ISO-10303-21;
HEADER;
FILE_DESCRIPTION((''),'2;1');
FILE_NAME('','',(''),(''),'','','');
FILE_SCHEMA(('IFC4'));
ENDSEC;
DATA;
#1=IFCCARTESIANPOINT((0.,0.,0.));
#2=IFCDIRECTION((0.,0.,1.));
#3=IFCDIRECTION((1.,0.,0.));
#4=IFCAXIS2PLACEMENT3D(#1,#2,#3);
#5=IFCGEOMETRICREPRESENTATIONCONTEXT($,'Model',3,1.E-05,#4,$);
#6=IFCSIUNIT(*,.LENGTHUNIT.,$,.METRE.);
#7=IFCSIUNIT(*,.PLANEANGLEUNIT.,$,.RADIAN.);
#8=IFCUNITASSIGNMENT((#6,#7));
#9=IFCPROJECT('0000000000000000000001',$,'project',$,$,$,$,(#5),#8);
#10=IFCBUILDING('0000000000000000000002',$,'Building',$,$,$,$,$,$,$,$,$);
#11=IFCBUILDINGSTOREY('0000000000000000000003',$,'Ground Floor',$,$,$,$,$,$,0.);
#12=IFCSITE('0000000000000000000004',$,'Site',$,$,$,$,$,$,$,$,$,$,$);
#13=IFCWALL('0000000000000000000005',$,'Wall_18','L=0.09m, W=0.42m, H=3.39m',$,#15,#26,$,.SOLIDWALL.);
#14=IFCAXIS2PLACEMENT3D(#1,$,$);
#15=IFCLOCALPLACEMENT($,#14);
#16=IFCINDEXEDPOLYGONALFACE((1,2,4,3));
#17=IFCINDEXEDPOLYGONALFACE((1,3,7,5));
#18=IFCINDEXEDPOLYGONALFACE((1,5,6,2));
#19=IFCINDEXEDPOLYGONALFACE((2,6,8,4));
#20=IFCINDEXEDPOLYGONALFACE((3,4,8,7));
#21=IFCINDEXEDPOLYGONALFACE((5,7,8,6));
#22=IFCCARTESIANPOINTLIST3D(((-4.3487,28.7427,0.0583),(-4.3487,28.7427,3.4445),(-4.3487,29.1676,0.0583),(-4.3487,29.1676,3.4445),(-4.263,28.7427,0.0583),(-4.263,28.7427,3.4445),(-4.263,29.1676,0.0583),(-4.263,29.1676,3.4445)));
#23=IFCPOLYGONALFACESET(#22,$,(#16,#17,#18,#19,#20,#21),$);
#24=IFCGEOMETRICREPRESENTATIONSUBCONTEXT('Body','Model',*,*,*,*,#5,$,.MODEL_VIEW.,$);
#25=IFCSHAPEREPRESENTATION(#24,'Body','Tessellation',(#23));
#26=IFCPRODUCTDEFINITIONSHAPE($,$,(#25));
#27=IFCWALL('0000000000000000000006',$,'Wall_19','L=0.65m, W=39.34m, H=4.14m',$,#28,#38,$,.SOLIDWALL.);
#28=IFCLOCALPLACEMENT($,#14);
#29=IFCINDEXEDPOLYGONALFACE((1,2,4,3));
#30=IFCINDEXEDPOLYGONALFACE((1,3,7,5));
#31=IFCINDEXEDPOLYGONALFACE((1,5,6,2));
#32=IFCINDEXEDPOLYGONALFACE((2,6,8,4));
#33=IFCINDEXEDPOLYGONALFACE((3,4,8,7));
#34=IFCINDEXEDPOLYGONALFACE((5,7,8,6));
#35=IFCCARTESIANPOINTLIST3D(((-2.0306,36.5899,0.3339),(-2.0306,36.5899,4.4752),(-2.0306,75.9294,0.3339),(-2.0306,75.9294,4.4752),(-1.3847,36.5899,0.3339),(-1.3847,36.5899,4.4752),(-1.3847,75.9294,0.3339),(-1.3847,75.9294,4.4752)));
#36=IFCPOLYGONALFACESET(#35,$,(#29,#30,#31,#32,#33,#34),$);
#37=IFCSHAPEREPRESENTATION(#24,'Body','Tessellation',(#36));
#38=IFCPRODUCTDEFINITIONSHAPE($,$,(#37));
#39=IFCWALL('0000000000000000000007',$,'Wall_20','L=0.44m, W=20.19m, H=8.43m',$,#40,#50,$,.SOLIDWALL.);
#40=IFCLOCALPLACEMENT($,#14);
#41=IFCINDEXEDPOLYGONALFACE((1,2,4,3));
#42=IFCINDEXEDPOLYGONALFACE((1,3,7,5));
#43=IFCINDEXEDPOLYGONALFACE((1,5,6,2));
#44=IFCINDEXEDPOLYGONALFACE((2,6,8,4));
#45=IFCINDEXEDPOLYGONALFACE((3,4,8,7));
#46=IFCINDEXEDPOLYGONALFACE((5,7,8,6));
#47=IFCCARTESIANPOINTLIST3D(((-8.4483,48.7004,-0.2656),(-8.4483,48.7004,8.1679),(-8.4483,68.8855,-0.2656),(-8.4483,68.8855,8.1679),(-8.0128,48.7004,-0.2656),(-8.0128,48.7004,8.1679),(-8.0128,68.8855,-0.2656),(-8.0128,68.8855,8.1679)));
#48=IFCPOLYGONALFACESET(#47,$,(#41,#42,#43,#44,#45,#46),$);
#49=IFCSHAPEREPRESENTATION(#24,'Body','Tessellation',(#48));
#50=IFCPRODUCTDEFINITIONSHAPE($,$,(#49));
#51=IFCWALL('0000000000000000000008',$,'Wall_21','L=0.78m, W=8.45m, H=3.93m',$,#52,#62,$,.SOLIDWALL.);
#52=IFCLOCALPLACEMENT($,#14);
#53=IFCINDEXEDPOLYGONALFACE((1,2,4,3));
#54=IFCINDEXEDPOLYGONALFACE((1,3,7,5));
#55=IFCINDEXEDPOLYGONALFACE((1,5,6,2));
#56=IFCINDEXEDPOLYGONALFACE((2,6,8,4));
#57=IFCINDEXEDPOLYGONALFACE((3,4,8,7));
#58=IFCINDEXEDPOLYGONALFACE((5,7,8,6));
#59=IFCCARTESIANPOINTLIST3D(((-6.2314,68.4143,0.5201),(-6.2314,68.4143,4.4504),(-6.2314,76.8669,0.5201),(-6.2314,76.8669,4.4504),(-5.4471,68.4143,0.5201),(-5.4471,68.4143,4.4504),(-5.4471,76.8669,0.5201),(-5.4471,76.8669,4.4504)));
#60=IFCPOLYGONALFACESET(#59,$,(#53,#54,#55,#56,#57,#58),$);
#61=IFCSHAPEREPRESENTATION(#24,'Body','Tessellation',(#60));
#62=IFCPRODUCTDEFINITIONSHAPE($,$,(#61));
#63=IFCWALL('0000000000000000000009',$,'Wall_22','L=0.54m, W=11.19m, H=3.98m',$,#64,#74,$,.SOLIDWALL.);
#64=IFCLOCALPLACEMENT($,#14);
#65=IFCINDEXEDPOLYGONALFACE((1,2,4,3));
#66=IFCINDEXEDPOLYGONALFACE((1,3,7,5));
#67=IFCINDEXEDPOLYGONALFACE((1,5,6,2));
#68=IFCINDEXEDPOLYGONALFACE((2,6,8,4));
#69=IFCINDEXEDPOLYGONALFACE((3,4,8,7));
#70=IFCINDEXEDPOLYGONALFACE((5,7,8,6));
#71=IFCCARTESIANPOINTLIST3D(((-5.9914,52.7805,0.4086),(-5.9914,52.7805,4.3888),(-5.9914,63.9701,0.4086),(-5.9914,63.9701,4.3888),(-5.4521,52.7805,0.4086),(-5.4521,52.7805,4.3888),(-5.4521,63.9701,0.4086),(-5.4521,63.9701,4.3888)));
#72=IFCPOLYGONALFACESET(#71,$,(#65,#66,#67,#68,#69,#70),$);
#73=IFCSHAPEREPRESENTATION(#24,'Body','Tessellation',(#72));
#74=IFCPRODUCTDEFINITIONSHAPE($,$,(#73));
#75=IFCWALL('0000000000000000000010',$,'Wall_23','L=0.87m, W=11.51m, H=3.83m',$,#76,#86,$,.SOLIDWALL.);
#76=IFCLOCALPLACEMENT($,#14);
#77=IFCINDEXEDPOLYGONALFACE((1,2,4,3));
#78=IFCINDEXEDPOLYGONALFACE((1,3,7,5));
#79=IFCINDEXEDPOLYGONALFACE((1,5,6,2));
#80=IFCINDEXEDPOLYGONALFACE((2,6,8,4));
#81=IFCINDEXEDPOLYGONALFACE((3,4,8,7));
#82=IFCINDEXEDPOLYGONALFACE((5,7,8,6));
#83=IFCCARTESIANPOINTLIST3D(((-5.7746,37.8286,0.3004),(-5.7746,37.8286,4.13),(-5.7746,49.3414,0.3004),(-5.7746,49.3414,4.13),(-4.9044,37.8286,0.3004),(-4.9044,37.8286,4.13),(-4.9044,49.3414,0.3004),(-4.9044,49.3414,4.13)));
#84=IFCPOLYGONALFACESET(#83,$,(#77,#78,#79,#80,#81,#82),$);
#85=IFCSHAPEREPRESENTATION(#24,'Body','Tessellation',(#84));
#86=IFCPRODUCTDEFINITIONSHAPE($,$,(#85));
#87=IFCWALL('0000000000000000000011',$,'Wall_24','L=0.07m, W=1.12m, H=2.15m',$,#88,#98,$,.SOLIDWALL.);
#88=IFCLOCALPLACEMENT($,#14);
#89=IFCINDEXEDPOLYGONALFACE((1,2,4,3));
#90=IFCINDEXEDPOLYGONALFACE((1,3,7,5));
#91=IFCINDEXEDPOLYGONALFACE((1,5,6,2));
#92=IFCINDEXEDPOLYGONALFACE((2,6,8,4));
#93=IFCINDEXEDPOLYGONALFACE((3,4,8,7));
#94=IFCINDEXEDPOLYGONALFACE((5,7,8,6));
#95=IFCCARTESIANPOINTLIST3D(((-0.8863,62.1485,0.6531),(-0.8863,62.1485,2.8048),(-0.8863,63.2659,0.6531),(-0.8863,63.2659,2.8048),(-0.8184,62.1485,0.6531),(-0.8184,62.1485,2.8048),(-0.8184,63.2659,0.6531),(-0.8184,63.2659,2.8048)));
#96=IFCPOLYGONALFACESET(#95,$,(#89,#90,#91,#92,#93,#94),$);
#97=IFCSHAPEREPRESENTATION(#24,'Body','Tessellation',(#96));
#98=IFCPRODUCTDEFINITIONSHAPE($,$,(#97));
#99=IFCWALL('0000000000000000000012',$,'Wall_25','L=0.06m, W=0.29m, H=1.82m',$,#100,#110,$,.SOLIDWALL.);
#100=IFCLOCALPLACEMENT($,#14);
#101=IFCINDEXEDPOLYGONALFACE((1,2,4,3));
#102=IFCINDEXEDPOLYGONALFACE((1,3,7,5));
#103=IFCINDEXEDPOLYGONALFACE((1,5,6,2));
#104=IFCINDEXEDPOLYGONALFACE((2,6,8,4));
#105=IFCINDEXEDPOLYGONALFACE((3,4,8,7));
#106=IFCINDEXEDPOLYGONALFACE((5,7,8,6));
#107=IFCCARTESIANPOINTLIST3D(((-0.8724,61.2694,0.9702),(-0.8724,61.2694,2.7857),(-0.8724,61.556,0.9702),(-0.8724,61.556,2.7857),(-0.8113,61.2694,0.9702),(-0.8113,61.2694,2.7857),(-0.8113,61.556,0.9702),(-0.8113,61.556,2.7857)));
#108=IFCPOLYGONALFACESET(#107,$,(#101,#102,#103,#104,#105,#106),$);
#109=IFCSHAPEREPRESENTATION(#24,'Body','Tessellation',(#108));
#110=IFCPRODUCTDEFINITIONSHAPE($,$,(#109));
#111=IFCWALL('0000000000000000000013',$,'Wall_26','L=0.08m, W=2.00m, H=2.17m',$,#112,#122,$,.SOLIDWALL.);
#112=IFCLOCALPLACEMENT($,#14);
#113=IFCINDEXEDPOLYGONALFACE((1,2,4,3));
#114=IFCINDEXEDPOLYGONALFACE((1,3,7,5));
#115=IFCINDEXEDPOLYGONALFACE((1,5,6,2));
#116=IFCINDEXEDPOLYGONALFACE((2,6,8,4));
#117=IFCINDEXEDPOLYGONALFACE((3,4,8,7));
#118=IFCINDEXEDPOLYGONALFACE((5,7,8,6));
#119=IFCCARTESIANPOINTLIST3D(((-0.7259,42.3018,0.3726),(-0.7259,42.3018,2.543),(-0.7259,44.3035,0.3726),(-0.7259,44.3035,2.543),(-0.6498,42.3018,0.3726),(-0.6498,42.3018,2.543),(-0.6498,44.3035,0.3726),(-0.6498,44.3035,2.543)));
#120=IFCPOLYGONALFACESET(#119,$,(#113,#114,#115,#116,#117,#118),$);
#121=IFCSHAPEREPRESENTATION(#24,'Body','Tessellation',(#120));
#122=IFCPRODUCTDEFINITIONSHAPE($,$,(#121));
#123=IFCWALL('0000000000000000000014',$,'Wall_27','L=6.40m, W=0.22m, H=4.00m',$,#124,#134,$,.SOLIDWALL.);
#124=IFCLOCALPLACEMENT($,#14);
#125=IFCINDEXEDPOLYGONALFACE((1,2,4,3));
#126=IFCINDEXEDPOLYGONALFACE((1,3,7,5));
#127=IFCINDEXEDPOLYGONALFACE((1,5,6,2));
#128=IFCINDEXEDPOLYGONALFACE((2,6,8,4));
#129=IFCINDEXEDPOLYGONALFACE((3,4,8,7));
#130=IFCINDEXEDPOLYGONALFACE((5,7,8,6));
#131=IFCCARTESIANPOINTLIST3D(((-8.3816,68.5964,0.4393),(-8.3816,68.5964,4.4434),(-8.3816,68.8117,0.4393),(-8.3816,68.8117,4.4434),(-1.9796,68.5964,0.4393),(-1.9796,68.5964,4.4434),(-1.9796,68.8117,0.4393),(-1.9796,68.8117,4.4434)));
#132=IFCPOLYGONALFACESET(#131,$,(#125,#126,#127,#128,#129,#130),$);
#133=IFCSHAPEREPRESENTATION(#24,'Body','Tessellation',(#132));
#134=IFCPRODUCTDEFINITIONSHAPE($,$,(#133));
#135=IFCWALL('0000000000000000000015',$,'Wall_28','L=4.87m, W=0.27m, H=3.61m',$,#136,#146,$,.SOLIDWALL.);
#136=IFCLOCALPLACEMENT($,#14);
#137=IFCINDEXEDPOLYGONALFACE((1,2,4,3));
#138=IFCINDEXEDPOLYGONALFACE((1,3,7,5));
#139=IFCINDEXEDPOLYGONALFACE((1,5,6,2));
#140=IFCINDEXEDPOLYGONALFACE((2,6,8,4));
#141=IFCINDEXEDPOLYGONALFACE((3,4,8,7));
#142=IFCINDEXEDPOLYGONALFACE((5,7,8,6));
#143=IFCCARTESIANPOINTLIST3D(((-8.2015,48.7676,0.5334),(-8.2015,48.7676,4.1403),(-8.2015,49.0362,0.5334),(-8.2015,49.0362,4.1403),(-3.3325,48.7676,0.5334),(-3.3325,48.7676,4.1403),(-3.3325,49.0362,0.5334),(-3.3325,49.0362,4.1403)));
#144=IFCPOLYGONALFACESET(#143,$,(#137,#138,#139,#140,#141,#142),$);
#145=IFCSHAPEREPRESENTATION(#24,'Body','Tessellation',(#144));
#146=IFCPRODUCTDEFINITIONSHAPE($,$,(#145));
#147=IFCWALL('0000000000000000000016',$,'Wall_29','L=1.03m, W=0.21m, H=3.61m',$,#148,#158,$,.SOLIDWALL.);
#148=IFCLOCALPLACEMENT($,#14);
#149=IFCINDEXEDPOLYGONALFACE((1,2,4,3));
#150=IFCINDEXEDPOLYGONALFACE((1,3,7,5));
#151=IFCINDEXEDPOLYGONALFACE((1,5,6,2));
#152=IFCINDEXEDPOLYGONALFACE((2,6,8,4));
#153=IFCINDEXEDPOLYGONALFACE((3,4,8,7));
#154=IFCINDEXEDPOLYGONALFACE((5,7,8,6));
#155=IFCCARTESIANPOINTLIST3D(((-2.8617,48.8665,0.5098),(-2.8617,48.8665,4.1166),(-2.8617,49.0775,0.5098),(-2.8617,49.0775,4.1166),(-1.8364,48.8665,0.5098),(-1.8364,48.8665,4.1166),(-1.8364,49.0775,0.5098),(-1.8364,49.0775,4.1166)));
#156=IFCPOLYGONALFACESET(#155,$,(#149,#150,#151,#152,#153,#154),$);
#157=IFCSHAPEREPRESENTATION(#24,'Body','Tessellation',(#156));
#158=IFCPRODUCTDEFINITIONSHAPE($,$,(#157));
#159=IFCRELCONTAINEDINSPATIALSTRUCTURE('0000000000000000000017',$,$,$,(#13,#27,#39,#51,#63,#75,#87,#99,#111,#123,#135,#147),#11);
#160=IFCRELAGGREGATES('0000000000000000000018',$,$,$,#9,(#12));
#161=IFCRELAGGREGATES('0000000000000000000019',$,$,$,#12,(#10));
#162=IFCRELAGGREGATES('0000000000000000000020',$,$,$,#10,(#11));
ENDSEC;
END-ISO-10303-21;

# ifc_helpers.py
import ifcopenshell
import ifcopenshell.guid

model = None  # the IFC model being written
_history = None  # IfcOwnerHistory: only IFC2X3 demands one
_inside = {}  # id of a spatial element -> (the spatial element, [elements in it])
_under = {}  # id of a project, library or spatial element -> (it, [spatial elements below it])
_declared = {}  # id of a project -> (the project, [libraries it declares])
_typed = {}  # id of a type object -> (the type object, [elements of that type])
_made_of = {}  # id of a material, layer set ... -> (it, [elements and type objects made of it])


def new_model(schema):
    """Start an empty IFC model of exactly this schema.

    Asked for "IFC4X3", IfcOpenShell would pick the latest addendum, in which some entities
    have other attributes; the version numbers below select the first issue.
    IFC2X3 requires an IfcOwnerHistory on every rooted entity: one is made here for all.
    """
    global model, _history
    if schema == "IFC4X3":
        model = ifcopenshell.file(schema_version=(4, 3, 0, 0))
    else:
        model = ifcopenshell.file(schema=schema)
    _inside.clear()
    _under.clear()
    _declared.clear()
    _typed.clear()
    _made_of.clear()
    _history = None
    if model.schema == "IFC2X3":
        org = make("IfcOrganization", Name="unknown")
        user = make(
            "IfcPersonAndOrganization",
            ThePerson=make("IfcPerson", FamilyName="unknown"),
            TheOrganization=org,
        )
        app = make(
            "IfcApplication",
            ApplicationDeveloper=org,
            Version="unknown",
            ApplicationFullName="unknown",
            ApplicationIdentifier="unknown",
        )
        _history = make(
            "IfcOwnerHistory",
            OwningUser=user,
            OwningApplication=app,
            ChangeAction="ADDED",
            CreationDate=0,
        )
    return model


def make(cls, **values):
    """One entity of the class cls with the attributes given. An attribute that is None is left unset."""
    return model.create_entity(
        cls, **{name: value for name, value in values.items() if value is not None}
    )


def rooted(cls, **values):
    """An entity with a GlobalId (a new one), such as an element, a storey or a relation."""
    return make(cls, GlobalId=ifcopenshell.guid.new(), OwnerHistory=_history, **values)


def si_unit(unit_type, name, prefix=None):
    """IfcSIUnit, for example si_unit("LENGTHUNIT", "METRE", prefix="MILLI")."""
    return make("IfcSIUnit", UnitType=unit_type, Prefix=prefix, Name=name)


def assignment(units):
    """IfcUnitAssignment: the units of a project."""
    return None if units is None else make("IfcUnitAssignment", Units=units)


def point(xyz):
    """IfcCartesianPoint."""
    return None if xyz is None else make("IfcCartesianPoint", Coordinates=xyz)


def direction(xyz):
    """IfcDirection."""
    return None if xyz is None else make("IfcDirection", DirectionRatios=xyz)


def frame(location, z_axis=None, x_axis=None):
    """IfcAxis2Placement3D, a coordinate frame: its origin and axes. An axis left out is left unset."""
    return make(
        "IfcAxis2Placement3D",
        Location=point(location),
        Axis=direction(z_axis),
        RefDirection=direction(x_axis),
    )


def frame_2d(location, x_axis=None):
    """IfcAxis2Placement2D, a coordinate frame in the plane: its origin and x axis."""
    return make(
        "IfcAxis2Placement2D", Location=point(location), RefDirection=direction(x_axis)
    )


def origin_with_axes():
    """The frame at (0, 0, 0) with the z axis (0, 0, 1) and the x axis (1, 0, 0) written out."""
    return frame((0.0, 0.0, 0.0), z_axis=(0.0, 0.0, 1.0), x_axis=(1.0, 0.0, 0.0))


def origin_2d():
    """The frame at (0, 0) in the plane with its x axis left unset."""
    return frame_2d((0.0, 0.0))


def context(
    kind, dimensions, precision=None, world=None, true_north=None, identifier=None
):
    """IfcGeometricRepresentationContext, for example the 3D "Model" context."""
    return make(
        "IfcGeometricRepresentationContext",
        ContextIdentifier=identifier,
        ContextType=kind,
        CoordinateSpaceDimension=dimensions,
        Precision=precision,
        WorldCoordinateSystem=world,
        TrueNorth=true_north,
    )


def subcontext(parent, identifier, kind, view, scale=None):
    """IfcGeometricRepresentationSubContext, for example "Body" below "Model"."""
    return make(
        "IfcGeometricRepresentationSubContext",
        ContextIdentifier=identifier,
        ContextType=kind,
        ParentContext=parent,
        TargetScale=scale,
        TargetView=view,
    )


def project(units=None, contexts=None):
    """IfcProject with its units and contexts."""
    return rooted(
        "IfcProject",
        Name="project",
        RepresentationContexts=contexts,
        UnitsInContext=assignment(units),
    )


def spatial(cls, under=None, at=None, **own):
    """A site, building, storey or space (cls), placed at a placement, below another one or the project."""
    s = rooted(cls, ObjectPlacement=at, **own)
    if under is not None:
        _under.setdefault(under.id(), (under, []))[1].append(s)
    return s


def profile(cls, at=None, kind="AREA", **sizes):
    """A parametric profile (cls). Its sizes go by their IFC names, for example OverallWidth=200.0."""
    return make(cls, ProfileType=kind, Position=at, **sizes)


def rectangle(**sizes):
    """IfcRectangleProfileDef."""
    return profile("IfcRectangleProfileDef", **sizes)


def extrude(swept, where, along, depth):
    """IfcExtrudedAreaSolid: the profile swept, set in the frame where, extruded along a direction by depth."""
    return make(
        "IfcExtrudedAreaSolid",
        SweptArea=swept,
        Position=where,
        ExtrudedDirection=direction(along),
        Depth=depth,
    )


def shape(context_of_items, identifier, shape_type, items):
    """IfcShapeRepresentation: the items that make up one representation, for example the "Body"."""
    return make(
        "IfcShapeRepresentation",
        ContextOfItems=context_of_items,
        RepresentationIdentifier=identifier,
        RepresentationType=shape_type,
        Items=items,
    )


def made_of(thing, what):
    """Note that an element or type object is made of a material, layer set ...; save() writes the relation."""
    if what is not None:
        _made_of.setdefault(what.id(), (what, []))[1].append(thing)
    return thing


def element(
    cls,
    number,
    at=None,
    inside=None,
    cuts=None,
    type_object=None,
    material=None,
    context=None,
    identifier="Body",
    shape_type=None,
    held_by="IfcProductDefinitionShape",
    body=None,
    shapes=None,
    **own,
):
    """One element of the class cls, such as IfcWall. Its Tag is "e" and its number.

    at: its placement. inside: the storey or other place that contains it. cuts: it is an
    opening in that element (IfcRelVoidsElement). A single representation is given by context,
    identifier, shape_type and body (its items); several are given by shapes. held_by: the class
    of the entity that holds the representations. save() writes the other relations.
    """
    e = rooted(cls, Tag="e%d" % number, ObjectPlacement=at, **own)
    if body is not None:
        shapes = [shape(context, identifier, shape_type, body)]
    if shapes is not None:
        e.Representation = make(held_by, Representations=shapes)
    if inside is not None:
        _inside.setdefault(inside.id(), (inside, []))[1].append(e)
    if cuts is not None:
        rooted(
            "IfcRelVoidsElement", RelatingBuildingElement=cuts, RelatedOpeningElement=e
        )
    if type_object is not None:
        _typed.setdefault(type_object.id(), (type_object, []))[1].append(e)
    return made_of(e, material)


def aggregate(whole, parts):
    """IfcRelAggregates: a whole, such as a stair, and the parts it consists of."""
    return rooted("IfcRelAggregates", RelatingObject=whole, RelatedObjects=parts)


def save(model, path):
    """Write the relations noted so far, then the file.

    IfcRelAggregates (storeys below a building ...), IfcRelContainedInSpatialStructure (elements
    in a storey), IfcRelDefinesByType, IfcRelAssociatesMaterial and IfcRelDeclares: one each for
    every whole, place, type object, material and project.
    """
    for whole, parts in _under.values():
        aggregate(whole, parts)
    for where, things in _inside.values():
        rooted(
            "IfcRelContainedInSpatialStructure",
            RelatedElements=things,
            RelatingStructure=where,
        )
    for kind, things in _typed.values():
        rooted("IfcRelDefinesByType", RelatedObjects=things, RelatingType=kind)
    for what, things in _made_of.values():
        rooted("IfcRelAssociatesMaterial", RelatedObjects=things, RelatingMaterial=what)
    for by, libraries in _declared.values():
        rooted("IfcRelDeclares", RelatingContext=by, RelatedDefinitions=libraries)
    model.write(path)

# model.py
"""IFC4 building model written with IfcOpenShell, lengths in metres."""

from ifc_helpers import new_model, si_unit, frame, origin_with_axes, origin_2d, context, subcontext, project, spatial, rectangle, extrude, element, save


model = new_model("IFC4")

# Units and contexts
model_context = context("Model", 3, precision=1e-05, world=origin_with_axes())
body_context = subcontext(model_context, "Body", "Model", "MODEL_VIEW")
ifc_project = project(units=[si_unit("LENGTHUNIT", "METRE"), si_unit("PLANEANGLEUNIT", "RADIAN")], contexts=[model_context])

# Site, building, storey
site = spatial("IfcSite", under=ifc_project, Name="Site")
building = spatial("IfcBuilding", under=site, Name="Building")
storey = spatial("IfcBuildingStorey", under=building, Name="Ground Floor", Elevation=0.0)

# Walls
element("IfcWall", 1, inside=storey, Name="Wall_18", Description="L=0.09m, W=0.42m, H=3.39m", PredefinedType="SOLIDWALL", context=body_context, shape_type="SweptSolid", body=[
    extrude(rectangle(XDim=0.0857, YDim=0.4249, at=origin_2d()), frame((-4.3058, 28.9551, 0.0583), z_axis=(0.0, 0.0, 1.0), x_axis=(1.0, 0.0, 0.0)), (0.0, 0.0, 1.0), 3.3862),
])
element("IfcWall", 2, inside=storey, Name="Wall_19", Description="L=0.65m, W=39.34m, H=4.14m", PredefinedType="SOLIDWALL", context=body_context, shape_type="SweptSolid", body=[
    extrude(rectangle(XDim=0.6459, YDim=39.3394, at=origin_2d()), frame((-1.7077, 56.2597, 0.3339), z_axis=(0.0, 0.0, 1.0), x_axis=(1.0, 0.0, 0.0)), (0.0, 0.0, 1.0), 4.1413),
])
element("IfcWall", 3, inside=storey, Name="Wall_20", Description="L=0.44m, W=20.19m, H=8.43m", PredefinedType="SOLIDWALL", context=body_context, shape_type="SweptSolid", body=[
    extrude(rectangle(XDim=0.4355, YDim=20.1851, at=origin_2d()), frame((-8.2305, 58.7929, -0.2656), z_axis=(0.0, 0.0, 1.0), x_axis=(1.0, 0.0, 0.0)), (0.0, 0.0, 1.0), 8.4335),
])
element("IfcWall", 4, inside=storey, Name="Wall_21", Description="L=0.78m, W=8.45m, H=3.93m", PredefinedType="SOLIDWALL", context=body_context, shape_type="SweptSolid", body=[
    extrude(rectangle(XDim=0.7843, YDim=8.4526, at=origin_2d()), frame((-5.8392, 72.6406, 0.5201), z_axis=(0.0, 0.0, 1.0), x_axis=(1.0, 0.0, 0.0)), (0.0, 0.0, 1.0), 3.9304),
])
element("IfcWall", 5, inside=storey, Name="Wall_22", Description="L=0.54m, W=11.19m, H=3.98m", PredefinedType="SOLIDWALL", context=body_context, shape_type="SweptSolid", body=[
    extrude(rectangle(XDim=0.5393, YDim=11.1896, at=origin_2d()), frame((-5.7218, 58.3753, 0.4086), z_axis=(0.0, 0.0, 1.0), x_axis=(1.0, 0.0, 0.0)), (0.0, 0.0, 1.0), 3.9801),
])
element("IfcWall", 6, inside=storey, Name="Wall_23", Description="L=0.87m, W=11.51m, H=3.83m", PredefinedType="SOLIDWALL", context=body_context, shape_type="SweptSolid", body=[
    extrude(rectangle(XDim=0.8702, YDim=11.5128, at=origin_2d()), frame((-5.3395, 43.585, 0.3004), z_axis=(0.0, 0.0, 1.0), x_axis=(1.0, 0.0, 0.0)), (0.0, 0.0, 1.0), 3.8297),
])
element("IfcWall", 7, inside=storey, Name="Wall_24", Description="L=0.07m, W=1.12m, H=2.15m", PredefinedType="SOLIDWALL", context=body_context, shape_type="SweptSolid", body=[
    extrude(rectangle(XDim=0.068, YDim=1.1173, at=origin_2d()), frame((-0.8524, 62.7072, 0.6531), z_axis=(0.0, 0.0, 1.0), x_axis=(1.0, 0.0, 0.0)), (0.0, 0.0, 1.0), 2.1517),
])
element("IfcWall", 8, inside=storey, Name="Wall_25", Description="L=0.06m, W=0.29m, H=1.82m", PredefinedType="SOLIDWALL", context=body_context, shape_type="SweptSolid", body=[
    extrude(rectangle(XDim=0.0611, YDim=0.2866, at=origin_2d()), frame((-0.8419, 61.4127, 0.9702), z_axis=(0.0, 0.0, 1.0), x_axis=(1.0, 0.0, 0.0)), (0.0, 0.0, 1.0), 1.8156),
])
element("IfcWall", 9, inside=storey, Name="Wall_26", Description="L=0.08m, W=2.00m, H=2.17m", PredefinedType="SOLIDWALL", context=body_context, shape_type="SweptSolid", body=[
    extrude(rectangle(XDim=0.0761, YDim=2.0017, at=origin_2d()), frame((-0.6879, 43.3026, 0.3726), z_axis=(0.0, 0.0, 1.0), x_axis=(1.0, 0.0, 0.0)), (0.0, 0.0, 1.0), 2.1704),
])
element("IfcWall", 10, inside=storey, Name="Wall_27", Description="L=6.40m, W=0.22m, H=4.00m", PredefinedType="SOLIDWALL", context=body_context, shape_type="SweptSolid", body=[
    extrude(rectangle(XDim=6.4019, YDim=0.2153, at=origin_2d()), frame((-5.1806, 68.704, 0.4393), z_axis=(0.0, 0.0, 1.0), x_axis=(1.0, 0.0, 0.0)), (0.0, 0.0, 1.0), 4.0042),
])
element("IfcWall", 11, inside=storey, Name="Wall_28", Description="L=4.87m, W=0.27m, H=3.61m", PredefinedType="SOLIDWALL", context=body_context, shape_type="SweptSolid", body=[
    extrude(rectangle(XDim=4.869, YDim=0.2687, at=origin_2d()), frame((-5.767, 48.9019, 0.5334), z_axis=(0.0, 0.0, 1.0), x_axis=(1.0, 0.0, 0.0)), (0.0, 0.0, 1.0), 3.6069),
])
element("IfcWall", 12, inside=storey, Name="Wall_29", Description="L=1.03m, W=0.21m, H=3.61m", PredefinedType="SOLIDWALL", context=body_context, shape_type="SweptSolid", body=[
    extrude(rectangle(XDim=1.0253, YDim=0.211, at=origin_2d()), frame((-2.349, 48.972, 0.5098), z_axis=(0.0, 0.0, 1.0), x_axis=(1.0, 0.0, 0.0)), (0.0, 0.0, 1.0), 3.6068),
])

save(model, "model.ifc")
